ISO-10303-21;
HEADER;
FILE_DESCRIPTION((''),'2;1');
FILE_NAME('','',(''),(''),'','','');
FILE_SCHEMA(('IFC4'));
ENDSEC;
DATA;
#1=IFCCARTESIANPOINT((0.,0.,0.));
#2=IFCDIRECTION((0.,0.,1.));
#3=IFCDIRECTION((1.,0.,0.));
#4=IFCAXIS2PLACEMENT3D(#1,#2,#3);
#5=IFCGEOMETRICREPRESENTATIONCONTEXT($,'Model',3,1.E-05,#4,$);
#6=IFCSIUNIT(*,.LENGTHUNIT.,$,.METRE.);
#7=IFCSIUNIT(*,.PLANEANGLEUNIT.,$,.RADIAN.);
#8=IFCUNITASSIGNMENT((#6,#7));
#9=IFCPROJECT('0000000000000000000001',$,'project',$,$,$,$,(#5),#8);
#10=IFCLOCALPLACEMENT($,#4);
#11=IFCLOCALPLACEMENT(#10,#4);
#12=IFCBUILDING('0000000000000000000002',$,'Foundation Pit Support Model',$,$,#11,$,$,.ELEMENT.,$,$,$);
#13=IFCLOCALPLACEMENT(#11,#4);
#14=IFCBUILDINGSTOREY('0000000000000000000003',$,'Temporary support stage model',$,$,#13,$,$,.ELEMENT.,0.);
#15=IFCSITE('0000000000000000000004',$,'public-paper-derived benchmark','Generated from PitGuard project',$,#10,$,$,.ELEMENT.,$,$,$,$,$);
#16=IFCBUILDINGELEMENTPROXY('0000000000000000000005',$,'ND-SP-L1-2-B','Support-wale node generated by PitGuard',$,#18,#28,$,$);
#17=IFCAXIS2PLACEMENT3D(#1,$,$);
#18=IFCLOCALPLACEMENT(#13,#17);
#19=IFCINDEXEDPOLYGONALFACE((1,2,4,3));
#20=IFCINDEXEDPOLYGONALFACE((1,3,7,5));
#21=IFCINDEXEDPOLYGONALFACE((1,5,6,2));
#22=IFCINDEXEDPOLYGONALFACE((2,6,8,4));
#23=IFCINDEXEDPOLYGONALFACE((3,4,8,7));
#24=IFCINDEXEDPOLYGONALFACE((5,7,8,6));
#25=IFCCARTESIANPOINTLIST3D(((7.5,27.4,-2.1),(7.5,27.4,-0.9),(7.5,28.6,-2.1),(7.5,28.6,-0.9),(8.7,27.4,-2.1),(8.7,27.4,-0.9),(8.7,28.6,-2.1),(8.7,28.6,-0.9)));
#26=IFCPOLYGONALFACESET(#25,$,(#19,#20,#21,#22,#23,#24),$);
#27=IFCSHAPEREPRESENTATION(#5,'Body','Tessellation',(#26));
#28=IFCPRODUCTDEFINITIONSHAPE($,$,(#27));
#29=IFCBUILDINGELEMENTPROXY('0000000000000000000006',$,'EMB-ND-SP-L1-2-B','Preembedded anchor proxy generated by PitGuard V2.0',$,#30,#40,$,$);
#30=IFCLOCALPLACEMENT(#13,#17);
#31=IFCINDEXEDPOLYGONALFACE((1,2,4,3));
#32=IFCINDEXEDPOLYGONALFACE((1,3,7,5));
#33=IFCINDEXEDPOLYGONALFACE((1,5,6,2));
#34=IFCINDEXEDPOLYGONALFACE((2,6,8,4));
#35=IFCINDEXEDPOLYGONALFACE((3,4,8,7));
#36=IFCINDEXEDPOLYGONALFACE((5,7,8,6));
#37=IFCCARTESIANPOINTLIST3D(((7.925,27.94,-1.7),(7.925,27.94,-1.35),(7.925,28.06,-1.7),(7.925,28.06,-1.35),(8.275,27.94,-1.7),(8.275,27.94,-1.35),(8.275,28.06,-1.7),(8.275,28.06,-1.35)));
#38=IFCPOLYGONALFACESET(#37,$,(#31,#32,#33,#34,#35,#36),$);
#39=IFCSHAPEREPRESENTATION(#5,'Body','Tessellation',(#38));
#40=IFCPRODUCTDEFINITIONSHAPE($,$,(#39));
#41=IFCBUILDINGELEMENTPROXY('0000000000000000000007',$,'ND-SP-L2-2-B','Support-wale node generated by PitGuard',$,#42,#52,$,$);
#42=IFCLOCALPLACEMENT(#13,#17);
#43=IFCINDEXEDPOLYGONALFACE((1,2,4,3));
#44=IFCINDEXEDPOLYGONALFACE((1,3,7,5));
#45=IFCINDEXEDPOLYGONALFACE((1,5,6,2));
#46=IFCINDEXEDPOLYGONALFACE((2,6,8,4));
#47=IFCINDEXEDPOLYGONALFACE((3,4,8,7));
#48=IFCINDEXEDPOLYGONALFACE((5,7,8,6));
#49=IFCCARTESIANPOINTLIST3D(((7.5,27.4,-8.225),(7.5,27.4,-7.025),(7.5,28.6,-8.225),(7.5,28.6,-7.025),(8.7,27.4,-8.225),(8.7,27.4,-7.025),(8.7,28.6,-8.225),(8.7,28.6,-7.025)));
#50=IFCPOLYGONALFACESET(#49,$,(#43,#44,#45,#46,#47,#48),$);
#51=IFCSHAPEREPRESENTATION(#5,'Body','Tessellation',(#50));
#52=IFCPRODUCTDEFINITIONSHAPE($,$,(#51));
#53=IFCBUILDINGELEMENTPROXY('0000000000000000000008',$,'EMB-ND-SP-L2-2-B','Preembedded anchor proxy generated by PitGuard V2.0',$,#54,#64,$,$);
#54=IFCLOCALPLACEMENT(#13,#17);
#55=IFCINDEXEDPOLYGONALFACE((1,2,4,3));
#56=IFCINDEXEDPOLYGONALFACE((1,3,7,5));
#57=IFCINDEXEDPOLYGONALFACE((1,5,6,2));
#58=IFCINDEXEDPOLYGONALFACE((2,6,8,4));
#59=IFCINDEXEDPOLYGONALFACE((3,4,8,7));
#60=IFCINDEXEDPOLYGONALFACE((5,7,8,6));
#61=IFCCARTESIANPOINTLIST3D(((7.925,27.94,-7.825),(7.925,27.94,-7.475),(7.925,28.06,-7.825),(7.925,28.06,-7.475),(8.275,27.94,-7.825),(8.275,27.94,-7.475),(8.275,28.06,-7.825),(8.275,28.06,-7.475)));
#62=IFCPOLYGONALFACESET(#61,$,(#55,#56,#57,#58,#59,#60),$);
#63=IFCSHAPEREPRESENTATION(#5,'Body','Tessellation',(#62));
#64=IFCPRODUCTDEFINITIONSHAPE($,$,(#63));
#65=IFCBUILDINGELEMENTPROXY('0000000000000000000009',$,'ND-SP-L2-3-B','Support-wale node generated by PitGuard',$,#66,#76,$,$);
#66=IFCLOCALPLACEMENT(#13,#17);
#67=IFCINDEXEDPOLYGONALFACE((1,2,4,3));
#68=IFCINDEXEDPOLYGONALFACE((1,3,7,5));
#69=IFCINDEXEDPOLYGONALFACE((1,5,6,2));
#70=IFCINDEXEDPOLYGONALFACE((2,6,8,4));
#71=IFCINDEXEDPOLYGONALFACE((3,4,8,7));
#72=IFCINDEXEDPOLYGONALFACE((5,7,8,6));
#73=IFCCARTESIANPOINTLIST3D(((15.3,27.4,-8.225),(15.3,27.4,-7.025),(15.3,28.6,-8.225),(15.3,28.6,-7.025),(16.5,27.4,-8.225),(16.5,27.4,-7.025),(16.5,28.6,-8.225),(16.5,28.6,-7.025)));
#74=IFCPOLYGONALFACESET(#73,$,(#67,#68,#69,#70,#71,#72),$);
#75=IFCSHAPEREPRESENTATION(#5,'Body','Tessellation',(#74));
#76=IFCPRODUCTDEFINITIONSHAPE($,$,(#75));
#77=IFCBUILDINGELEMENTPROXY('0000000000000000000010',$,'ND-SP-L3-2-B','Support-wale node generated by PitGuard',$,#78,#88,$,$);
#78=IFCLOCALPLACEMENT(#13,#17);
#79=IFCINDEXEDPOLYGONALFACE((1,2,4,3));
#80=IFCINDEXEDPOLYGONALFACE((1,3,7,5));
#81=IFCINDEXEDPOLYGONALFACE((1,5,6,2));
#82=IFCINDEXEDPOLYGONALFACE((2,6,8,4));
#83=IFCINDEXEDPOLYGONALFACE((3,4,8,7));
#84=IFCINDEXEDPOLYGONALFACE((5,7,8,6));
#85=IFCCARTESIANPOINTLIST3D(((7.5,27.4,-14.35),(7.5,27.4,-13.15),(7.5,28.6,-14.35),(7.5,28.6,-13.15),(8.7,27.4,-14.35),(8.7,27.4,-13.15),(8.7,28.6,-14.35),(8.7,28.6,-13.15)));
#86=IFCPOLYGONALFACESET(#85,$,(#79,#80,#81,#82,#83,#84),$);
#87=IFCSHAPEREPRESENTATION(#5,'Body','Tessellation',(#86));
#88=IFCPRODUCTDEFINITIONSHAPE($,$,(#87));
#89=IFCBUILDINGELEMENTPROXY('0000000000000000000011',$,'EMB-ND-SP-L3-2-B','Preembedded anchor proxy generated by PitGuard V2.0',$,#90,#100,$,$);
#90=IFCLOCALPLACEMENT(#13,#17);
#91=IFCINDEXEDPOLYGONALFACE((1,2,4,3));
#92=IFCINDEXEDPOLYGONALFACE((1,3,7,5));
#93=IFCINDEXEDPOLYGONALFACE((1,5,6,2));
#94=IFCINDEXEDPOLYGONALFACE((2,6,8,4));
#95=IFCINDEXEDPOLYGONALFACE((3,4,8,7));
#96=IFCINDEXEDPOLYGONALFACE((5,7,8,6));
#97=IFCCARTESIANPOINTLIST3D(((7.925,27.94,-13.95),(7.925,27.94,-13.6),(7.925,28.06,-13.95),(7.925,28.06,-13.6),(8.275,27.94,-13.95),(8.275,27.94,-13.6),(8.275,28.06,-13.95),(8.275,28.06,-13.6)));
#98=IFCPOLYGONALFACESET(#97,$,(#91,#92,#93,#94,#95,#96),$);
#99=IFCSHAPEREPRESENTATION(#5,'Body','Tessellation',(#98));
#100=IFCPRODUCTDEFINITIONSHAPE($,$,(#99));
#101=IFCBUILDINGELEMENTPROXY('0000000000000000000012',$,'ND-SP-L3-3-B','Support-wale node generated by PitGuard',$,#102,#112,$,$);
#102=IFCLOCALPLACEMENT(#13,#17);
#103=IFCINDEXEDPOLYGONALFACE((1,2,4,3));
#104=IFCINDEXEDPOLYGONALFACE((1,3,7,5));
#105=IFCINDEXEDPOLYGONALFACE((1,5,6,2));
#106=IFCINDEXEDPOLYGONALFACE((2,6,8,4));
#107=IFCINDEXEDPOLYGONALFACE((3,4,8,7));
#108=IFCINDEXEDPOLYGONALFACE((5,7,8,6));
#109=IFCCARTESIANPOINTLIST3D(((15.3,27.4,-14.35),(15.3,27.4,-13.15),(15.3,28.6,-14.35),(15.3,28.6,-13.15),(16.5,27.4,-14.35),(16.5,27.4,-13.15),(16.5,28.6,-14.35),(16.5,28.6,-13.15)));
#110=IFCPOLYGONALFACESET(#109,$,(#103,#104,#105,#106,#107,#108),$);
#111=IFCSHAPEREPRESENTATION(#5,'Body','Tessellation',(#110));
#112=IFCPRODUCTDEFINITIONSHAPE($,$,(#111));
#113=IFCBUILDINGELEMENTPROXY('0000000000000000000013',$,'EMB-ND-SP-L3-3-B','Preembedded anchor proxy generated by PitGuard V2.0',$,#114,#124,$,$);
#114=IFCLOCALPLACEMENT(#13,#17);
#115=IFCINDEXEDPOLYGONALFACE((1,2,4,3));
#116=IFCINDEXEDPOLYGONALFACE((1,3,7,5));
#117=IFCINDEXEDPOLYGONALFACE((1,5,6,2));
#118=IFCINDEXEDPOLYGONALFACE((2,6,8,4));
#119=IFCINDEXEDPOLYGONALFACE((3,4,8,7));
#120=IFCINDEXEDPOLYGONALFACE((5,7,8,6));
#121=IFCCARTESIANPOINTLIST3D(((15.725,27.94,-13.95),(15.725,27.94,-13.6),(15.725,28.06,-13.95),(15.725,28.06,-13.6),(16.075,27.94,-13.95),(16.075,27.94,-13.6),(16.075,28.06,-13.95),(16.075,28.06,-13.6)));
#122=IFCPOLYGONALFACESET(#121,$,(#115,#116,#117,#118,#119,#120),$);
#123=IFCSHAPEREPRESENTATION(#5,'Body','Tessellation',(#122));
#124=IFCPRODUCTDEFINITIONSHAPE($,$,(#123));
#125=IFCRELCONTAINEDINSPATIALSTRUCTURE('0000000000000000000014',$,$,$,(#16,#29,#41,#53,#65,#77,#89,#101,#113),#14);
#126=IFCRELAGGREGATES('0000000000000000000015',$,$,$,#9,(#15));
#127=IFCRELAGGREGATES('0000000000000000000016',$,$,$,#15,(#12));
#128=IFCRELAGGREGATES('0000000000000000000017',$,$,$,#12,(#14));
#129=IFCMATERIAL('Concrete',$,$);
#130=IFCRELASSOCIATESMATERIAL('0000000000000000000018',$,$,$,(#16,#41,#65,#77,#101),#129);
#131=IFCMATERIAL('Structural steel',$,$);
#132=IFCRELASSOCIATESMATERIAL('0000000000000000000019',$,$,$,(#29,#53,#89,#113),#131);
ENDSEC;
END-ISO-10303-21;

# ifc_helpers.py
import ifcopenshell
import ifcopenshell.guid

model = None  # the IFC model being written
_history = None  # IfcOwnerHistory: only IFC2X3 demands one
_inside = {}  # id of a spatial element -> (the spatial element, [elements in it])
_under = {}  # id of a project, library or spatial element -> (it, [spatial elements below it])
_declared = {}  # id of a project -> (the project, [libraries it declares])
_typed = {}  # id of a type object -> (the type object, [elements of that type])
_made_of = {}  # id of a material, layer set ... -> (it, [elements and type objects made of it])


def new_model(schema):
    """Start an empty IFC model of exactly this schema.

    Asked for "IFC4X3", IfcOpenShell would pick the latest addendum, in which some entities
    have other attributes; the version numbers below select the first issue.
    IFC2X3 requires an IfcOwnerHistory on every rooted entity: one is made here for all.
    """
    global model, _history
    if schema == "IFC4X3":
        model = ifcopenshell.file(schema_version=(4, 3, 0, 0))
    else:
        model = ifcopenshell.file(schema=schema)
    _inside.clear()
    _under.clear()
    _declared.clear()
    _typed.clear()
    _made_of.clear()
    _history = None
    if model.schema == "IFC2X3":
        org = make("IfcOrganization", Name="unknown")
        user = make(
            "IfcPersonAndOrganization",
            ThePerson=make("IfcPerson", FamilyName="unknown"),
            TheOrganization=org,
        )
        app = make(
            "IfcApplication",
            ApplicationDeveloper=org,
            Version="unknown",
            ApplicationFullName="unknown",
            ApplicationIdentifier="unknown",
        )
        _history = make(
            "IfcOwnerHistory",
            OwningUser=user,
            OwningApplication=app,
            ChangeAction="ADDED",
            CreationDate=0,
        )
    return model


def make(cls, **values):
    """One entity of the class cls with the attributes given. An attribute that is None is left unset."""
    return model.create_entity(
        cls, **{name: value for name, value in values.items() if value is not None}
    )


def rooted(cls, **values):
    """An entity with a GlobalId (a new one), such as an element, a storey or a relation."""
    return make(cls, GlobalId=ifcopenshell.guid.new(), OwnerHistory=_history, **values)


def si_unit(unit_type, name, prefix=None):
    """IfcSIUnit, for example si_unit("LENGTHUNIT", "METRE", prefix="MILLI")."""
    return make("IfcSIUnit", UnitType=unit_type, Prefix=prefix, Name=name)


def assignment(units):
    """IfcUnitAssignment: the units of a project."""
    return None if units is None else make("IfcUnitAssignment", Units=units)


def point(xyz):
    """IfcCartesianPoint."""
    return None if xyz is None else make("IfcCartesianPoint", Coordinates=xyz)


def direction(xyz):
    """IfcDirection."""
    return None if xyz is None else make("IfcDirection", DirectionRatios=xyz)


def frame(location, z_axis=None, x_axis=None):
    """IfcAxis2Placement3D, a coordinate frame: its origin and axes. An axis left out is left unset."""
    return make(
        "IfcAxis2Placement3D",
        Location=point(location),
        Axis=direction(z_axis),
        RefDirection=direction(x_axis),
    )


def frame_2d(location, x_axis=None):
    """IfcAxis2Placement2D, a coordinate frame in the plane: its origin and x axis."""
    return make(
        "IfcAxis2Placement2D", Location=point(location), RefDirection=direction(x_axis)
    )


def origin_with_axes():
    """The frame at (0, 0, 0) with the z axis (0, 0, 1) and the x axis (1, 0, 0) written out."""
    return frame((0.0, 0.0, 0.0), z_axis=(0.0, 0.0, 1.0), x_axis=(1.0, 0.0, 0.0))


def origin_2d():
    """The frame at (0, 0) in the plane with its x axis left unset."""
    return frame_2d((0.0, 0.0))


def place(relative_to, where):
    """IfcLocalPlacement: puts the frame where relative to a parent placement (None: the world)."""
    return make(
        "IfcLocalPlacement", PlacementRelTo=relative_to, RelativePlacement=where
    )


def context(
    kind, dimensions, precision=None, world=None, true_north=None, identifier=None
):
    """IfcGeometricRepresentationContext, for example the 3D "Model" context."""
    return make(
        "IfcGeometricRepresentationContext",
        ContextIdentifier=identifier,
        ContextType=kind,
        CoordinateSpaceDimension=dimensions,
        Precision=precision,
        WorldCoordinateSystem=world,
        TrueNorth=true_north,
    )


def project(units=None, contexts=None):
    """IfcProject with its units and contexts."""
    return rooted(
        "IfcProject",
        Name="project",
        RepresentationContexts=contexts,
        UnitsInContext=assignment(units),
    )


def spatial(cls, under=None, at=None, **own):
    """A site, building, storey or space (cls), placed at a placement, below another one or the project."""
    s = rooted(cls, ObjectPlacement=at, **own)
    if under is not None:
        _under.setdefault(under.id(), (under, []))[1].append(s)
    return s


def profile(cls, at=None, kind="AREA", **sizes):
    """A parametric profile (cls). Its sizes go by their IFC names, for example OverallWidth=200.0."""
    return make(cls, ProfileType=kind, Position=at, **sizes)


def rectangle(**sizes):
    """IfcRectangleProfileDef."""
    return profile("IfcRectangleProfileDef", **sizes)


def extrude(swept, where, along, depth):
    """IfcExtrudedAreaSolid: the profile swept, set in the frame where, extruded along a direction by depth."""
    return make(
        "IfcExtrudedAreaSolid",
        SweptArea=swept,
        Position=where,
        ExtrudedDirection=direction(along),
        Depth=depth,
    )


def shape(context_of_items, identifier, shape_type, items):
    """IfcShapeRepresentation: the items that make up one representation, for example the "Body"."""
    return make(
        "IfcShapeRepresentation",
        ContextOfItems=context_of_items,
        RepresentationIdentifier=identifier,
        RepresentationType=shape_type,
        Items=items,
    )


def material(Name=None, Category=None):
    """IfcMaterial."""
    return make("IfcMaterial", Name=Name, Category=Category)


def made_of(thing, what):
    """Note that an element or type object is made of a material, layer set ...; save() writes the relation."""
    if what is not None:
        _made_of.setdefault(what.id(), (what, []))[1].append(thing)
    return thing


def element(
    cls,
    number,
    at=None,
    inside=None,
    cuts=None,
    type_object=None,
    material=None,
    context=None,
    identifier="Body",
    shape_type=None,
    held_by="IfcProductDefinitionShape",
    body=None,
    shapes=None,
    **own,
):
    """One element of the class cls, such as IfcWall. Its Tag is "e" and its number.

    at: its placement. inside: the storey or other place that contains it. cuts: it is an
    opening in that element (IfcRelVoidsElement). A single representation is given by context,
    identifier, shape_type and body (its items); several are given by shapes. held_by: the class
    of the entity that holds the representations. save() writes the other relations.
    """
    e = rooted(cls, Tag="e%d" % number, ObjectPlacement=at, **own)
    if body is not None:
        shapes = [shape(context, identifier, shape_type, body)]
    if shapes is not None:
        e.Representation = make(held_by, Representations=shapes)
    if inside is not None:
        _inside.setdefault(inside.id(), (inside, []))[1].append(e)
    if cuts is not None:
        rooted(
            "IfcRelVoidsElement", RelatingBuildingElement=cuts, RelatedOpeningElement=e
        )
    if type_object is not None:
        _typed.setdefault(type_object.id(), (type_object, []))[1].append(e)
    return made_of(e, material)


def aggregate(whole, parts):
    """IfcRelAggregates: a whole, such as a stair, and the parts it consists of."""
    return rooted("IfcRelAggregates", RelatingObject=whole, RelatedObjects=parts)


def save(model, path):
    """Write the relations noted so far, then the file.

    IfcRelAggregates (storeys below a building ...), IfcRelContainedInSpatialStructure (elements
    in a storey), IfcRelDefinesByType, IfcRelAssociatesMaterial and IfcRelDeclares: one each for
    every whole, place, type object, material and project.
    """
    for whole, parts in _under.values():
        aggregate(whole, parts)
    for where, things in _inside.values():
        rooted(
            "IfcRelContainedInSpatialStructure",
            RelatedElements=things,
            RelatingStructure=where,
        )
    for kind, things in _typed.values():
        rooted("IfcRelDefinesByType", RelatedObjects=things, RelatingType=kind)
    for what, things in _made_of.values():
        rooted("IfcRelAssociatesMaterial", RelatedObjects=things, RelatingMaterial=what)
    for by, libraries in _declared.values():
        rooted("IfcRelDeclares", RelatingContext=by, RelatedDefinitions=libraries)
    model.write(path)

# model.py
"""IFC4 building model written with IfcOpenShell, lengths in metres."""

from ifc_helpers import new_model, si_unit, frame, origin_with_axes, origin_2d, place, context, project, spatial, rectangle, extrude, material, element, save


model = new_model("IFC4")

# Units and contexts
model_context = context("Model", 3, precision=1e-05, world=origin_with_axes())
ifc_project = project(units=[si_unit("LENGTHUNIT", "METRE"), si_unit("PLANEANGLEUNIT", "RADIAN")], contexts=[model_context])

# Site, building, storey
site_placement = place(None, origin_with_axes())
site = spatial("IfcSite", under=ifc_project, at=site_placement, Name="public-paper-derived benchmark", Description="Generated from PitGuard project", CompositionType="ELEMENT")
building_placement = place(site_placement, origin_with_axes())
building = spatial("IfcBuilding", under=site, at=building_placement, Name="Foundation Pit Support Model", CompositionType="ELEMENT")
storey_placement = place(building_placement, origin_with_axes())
storey = spatial("IfcBuildingStorey", under=building, at=storey_placement, Name="Temporary support stage model", CompositionType="ELEMENT", Elevation=0.0)

# Shared definitions
ifc_material_1 = material(Name="Concrete")

# Shared definitions
ifc_material_2 = material(Name="Structural steel")

# Building element proxies
proxy_1_placement = place(storey_placement, frame((8.1, 28.0, -2.1), z_axis=(0.0, 0.0, 1.0), x_axis=(1.0, 0.0, 0.0)))
element("IfcBuildingElementProxy", 1, at=proxy_1_placement, inside=storey, material=ifc_material_1, Name="ND-SP-L1-2-B", Description="Support-wale node generated by PitGuard", context=model_context, shape_type="SweptSolid", body=[
    extrude(rectangle(XDim=1.2, YDim=1.2, at=origin_2d()), origin_with_axes(), (0.0, 0.0, 1.0), 1.2),
])
proxy_2_placement = place(storey_placement, frame((8.1, 28.0, -1.7), z_axis=(0.0, 0.0, 1.0), x_axis=(1.0, 0.0, 0.0)))
element("IfcBuildingElementProxy", 2, at=proxy_2_placement, inside=storey, material=ifc_material_2, Name="EMB-ND-SP-L1-2-B", Description="Preembedded anchor proxy generated by PitGuard V2.0", context=model_context, shape_type="SweptSolid", body=[
    extrude(rectangle(XDim=0.35, YDim=0.12, at=origin_2d()), origin_with_axes(), (0.0, 0.0, 1.0), 0.35),
])
proxy_3_placement = place(storey_placement, frame((8.1, 28.0, -8.225), z_axis=(0.0, 0.0, 1.0), x_axis=(1.0, 0.0, 0.0)))
element("IfcBuildingElementProxy", 3, at=proxy_3_placement, inside=storey, material=ifc_material_1, Name="ND-SP-L2-2-B", Description="Support-wale node generated by PitGuard", context=model_context, shape_type="SweptSolid", body=[
    extrude(rectangle(XDim=1.2, YDim=1.2, at=origin_2d()), origin_with_axes(), (0.0, 0.0, 1.0), 1.2),
])
proxy_4_placement = place(storey_placement, frame((8.1, 28.0, -7.825), z_axis=(0.0, 0.0, 1.0), x_axis=(1.0, 0.0, 0.0)))
element("IfcBuildingElementProxy", 4, at=proxy_4_placement, inside=storey, material=ifc_material_2, Name="EMB-ND-SP-L2-2-B", Description="Preembedded anchor proxy generated by PitGuard V2.0", context=model_context, shape_type="SweptSolid", body=[
    extrude(rectangle(XDim=0.35, YDim=0.12, at=origin_2d()), origin_with_axes(), (0.0, 0.0, 1.0), 0.35),
])
for number, where, z_axis, x_axis, name in (
    (5, (15.9, 28.0, -8.225), (0.0, 0.0, 1.0), (1.0, 0.0, 0.0), "ND-SP-L2-3-B"),
    (6, (8.1, 28.0, -14.35), (0.0, 0.0, 1.0), (1.0, 0.0, 0.0), "ND-SP-L3-2-B"),
):
    element("IfcBuildingElementProxy", number, at=place(storey_placement, frame(where, z_axis=z_axis, x_axis=x_axis)), inside=storey, material=ifc_material_1, Name=name, Description="Support-wale node generated by PitGuard", context=model_context, shape_type="SweptSolid", body=[
        extrude(rectangle(XDim=1.2, YDim=1.2, at=origin_2d()), origin_with_axes(), (0.0, 0.0, 1.0), 1.2),
    ])
proxy_5_placement = place(storey_placement, frame((8.1, 28.0, -13.95), z_axis=(0.0, 0.0, 1.0), x_axis=(1.0, 0.0, 0.0)))
element("IfcBuildingElementProxy", 7, at=proxy_5_placement, inside=storey, material=ifc_material_2, Name="EMB-ND-SP-L3-2-B", Description="Preembedded anchor proxy generated by PitGuard V2.0", context=model_context, shape_type="SweptSolid", body=[
    extrude(rectangle(XDim=0.35, YDim=0.12, at=origin_2d()), origin_with_axes(), (0.0, 0.0, 1.0), 0.35),
])
proxy_6_placement = place(storey_placement, frame((15.9, 28.0, -14.35), z_axis=(0.0, 0.0, 1.0), x_axis=(1.0, 0.0, 0.0)))
element("IfcBuildingElementProxy", 8, at=proxy_6_placement, inside=storey, material=ifc_material_1, Name="ND-SP-L3-3-B", Description="Support-wale node generated by PitGuard", context=model_context, shape_type="SweptSolid", body=[
    extrude(rectangle(XDim=1.2, YDim=1.2, at=origin_2d()), origin_with_axes(), (0.0, 0.0, 1.0), 1.2),
])
proxy_7_placement = place(storey_placement, frame((15.9, 28.0, -13.95), z_axis=(0.0, 0.0, 1.0), x_axis=(1.0, 0.0, 0.0)))
element("IfcBuildingElementProxy", 9, at=proxy_7_placement, inside=storey, material=ifc_material_2, Name="EMB-ND-SP-L3-3-B", Description="Preembedded anchor proxy generated by PitGuard V2.0", context=model_context, shape_type="SweptSolid", body=[
    extrude(rectangle(XDim=0.35, YDim=0.12, at=origin_2d()), origin_with_axes(), (0.0, 0.0, 1.0), 0.35),
])

save(model, "model.ifc")
